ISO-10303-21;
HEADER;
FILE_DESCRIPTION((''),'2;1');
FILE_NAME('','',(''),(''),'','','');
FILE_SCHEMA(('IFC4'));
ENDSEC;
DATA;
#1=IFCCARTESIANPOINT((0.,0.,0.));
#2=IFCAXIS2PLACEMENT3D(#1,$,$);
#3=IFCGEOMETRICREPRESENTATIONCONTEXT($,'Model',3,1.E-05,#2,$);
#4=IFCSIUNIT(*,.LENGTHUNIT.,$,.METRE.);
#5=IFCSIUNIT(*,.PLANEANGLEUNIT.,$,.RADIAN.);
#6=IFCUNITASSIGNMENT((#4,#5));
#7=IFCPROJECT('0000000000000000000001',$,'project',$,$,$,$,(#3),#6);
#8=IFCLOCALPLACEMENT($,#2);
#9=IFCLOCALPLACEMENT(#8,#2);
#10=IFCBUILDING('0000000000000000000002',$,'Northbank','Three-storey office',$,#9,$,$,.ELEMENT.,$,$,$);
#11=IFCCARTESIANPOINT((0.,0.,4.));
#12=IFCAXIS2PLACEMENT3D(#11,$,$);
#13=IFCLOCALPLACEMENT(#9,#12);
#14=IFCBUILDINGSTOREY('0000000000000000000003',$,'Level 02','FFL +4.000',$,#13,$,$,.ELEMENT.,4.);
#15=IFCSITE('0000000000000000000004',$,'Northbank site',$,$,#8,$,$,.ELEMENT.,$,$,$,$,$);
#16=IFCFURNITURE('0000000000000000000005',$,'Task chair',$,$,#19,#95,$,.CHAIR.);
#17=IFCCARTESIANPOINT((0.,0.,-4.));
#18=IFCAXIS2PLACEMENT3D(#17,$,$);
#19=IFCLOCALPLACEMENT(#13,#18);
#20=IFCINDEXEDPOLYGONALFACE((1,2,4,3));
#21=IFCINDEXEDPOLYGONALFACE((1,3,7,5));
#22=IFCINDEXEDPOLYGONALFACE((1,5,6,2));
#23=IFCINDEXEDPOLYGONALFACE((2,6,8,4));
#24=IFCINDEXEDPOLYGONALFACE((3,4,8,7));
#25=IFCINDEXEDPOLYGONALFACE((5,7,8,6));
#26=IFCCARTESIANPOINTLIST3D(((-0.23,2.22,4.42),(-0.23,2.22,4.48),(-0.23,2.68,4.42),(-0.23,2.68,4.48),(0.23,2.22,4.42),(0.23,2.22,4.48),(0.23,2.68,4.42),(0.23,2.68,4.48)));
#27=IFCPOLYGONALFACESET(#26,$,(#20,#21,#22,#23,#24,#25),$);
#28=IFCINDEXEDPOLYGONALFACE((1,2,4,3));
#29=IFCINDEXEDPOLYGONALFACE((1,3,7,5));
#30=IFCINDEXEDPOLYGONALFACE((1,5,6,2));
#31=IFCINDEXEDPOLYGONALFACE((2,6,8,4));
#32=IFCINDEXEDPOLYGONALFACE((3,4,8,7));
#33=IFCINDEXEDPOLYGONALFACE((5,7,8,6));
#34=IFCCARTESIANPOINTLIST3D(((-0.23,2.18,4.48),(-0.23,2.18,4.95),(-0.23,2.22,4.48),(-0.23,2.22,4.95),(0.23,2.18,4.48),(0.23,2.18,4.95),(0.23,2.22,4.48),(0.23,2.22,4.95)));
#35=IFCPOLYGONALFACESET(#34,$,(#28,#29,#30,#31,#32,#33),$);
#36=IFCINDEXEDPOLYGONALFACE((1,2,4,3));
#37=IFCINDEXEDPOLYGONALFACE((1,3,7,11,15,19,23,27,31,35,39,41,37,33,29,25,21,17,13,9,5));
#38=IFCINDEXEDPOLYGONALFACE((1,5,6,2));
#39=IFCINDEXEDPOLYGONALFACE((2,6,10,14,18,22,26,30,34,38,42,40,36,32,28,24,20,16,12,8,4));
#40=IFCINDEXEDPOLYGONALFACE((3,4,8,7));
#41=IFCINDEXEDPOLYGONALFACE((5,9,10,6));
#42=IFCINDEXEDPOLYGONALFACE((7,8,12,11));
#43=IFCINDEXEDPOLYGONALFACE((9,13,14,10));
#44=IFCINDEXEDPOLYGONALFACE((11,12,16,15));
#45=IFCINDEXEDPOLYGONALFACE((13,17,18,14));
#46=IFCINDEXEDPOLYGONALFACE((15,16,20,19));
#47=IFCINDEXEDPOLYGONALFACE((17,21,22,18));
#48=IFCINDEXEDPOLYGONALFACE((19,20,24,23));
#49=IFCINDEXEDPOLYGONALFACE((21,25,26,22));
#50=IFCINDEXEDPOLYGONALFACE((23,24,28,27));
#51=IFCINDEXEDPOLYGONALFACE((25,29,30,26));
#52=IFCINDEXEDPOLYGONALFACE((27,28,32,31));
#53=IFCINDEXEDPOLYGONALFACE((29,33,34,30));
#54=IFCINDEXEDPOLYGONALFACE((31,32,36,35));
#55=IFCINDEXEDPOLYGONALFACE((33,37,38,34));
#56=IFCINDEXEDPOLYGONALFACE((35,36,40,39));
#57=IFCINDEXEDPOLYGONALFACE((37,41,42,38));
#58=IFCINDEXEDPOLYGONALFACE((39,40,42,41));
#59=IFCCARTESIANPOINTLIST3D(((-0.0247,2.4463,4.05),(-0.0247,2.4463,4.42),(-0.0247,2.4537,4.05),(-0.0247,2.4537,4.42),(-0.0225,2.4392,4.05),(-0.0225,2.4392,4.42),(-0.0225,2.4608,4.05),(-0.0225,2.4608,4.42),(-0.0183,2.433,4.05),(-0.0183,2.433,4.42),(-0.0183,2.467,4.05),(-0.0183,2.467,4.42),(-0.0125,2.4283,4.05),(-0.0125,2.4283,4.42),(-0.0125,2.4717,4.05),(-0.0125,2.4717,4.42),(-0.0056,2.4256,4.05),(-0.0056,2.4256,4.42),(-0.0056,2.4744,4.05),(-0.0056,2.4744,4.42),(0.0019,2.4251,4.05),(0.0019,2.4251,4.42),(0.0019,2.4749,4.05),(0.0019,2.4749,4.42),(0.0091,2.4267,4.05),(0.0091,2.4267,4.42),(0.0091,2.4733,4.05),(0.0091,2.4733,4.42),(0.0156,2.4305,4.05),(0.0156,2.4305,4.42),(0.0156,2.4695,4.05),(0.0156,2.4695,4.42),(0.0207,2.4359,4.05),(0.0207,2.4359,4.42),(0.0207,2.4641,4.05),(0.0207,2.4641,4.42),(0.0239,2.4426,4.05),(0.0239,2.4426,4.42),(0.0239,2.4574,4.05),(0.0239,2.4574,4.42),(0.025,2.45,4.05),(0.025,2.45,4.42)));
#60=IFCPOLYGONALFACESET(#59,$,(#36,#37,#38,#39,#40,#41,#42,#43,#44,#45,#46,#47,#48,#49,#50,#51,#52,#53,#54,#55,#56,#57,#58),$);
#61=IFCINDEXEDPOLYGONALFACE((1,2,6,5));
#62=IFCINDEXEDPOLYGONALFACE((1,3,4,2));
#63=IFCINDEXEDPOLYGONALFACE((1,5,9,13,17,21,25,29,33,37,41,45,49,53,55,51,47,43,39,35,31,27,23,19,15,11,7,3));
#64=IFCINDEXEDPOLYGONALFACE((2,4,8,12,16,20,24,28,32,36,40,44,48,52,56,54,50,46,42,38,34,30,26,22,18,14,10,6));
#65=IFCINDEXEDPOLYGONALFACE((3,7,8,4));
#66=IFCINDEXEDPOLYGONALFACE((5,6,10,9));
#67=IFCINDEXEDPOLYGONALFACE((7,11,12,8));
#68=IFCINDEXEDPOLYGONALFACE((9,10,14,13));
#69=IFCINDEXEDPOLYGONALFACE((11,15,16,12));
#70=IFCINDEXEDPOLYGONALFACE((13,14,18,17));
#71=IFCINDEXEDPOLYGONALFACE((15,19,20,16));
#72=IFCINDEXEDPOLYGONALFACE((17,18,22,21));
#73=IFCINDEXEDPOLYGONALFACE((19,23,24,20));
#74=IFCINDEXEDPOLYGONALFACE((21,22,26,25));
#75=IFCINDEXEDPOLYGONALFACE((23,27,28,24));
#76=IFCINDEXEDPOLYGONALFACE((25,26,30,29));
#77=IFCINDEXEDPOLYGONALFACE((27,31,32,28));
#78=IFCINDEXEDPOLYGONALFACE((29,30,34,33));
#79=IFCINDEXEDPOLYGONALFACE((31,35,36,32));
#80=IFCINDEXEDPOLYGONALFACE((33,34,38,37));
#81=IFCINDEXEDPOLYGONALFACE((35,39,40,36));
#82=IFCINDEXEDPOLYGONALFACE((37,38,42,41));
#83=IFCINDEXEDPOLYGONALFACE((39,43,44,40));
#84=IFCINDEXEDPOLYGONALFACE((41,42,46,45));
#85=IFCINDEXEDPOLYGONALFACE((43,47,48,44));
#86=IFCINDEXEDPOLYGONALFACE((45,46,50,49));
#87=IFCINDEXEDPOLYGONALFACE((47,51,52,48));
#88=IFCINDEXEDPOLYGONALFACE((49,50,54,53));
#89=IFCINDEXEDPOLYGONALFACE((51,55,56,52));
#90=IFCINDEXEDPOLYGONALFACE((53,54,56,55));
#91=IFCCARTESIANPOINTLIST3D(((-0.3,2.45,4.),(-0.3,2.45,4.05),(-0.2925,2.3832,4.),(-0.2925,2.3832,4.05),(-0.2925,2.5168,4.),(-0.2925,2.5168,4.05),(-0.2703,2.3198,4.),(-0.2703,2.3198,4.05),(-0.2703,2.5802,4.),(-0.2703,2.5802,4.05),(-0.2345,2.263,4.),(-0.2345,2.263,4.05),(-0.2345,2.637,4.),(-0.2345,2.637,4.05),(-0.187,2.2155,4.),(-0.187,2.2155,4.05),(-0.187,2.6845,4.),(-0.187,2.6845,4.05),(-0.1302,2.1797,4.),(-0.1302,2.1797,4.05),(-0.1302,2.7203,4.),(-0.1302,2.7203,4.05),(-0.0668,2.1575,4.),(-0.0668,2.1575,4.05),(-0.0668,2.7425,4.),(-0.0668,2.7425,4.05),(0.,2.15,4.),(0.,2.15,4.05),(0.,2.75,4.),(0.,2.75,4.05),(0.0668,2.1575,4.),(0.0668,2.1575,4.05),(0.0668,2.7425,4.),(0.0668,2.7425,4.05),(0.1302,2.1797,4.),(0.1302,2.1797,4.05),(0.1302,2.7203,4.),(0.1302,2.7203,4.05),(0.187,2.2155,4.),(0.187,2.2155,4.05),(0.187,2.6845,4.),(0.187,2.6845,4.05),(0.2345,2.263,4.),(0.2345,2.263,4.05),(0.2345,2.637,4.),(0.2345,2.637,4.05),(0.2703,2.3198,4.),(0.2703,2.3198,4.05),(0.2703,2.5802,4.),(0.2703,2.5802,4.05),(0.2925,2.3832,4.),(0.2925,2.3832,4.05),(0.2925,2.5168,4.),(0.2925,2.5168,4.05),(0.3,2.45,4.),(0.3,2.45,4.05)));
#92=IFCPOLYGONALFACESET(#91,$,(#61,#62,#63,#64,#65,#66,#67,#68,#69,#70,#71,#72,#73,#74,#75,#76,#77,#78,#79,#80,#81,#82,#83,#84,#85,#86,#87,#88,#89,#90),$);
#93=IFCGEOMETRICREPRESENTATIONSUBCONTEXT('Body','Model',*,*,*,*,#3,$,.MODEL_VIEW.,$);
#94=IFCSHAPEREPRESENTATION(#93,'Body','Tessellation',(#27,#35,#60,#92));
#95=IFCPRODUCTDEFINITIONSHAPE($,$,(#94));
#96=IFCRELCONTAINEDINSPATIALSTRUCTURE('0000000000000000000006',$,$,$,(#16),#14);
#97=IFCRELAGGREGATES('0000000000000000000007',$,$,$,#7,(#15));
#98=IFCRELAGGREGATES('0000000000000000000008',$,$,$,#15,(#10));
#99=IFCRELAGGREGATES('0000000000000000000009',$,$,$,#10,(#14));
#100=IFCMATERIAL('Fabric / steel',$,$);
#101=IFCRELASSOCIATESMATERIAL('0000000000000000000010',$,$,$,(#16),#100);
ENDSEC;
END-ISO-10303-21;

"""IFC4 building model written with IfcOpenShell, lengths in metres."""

from ifc_helpers import new_model, si_unit, frame, origin, place, context, subcontext, project, spatial, rectangle, circle, extrude, material, element, save


model = new_model("IFC4")

# Units and contexts
model_context = context("Model", 3, precision=1e-05, world=origin())
body_context = subcontext(model_context, "Body", "Model", "MODEL_VIEW")
ifc_project = project(units=[si_unit("LENGTHUNIT", "METRE"), si_unit("PLANEANGLEUNIT", "RADIAN")], contexts=[model_context])

# Site, building, storey
site_placement = place(None, origin())
site = spatial("IfcSite", under=ifc_project, at=site_placement, Name="Northbank site", CompositionType="ELEMENT")
building_placement = place(site_placement, origin())
building = spatial("IfcBuilding", under=site, at=building_placement, Name="Northbank", Description="Three-storey office", CompositionType="ELEMENT")
storey_placement = place(building_placement, frame((0.0, 0.0, 4.0)))
storey = spatial("IfcBuildingStorey", under=building, at=storey_placement, Name="Level 02", Description="FFL +4.000", CompositionType="ELEMENT", Elevation=4.0)

# Furniture
ifc_material_1 = material(Name="Fabric / steel")
furniture_1_placement = place(storey_placement, frame((0.0, 0.0, -4.0)))
element("IfcFurniture", 1, at=furniture_1_placement, inside=storey, material=ifc_material_1, Name="Task chair", PredefinedType="CHAIR", context=body_context, shape_type="SweptSolid", body=[
    extrude(rectangle(XDim=0.46, YDim=0.46), frame((0.0, 2.45, 4.42)), (0.0, 0.0, 1.0), 0.06),
    extrude(rectangle(XDim=0.46, YDim=0.04), frame((0.0, 2.2, 4.48)), (0.0, 0.0, 1.0), 0.47),
    extrude(circle(Radius=0.025), frame((0.0, 2.45, 4.05), z_axis=(0.0, 0.0, 1.0), x_axis=(1.0, 0.0, 0.0)), (0.0, 0.0, 1.0), 0.37),
    extrude(circle(Radius=0.3), frame((0.0, 2.45, 4.0), z_axis=(0.0, 0.0, 1.0), x_axis=(1.0, 0.0, 0.0)), (0.0, 0.0, 1.0), 0.05),
])

save(model, "model.ifc")
